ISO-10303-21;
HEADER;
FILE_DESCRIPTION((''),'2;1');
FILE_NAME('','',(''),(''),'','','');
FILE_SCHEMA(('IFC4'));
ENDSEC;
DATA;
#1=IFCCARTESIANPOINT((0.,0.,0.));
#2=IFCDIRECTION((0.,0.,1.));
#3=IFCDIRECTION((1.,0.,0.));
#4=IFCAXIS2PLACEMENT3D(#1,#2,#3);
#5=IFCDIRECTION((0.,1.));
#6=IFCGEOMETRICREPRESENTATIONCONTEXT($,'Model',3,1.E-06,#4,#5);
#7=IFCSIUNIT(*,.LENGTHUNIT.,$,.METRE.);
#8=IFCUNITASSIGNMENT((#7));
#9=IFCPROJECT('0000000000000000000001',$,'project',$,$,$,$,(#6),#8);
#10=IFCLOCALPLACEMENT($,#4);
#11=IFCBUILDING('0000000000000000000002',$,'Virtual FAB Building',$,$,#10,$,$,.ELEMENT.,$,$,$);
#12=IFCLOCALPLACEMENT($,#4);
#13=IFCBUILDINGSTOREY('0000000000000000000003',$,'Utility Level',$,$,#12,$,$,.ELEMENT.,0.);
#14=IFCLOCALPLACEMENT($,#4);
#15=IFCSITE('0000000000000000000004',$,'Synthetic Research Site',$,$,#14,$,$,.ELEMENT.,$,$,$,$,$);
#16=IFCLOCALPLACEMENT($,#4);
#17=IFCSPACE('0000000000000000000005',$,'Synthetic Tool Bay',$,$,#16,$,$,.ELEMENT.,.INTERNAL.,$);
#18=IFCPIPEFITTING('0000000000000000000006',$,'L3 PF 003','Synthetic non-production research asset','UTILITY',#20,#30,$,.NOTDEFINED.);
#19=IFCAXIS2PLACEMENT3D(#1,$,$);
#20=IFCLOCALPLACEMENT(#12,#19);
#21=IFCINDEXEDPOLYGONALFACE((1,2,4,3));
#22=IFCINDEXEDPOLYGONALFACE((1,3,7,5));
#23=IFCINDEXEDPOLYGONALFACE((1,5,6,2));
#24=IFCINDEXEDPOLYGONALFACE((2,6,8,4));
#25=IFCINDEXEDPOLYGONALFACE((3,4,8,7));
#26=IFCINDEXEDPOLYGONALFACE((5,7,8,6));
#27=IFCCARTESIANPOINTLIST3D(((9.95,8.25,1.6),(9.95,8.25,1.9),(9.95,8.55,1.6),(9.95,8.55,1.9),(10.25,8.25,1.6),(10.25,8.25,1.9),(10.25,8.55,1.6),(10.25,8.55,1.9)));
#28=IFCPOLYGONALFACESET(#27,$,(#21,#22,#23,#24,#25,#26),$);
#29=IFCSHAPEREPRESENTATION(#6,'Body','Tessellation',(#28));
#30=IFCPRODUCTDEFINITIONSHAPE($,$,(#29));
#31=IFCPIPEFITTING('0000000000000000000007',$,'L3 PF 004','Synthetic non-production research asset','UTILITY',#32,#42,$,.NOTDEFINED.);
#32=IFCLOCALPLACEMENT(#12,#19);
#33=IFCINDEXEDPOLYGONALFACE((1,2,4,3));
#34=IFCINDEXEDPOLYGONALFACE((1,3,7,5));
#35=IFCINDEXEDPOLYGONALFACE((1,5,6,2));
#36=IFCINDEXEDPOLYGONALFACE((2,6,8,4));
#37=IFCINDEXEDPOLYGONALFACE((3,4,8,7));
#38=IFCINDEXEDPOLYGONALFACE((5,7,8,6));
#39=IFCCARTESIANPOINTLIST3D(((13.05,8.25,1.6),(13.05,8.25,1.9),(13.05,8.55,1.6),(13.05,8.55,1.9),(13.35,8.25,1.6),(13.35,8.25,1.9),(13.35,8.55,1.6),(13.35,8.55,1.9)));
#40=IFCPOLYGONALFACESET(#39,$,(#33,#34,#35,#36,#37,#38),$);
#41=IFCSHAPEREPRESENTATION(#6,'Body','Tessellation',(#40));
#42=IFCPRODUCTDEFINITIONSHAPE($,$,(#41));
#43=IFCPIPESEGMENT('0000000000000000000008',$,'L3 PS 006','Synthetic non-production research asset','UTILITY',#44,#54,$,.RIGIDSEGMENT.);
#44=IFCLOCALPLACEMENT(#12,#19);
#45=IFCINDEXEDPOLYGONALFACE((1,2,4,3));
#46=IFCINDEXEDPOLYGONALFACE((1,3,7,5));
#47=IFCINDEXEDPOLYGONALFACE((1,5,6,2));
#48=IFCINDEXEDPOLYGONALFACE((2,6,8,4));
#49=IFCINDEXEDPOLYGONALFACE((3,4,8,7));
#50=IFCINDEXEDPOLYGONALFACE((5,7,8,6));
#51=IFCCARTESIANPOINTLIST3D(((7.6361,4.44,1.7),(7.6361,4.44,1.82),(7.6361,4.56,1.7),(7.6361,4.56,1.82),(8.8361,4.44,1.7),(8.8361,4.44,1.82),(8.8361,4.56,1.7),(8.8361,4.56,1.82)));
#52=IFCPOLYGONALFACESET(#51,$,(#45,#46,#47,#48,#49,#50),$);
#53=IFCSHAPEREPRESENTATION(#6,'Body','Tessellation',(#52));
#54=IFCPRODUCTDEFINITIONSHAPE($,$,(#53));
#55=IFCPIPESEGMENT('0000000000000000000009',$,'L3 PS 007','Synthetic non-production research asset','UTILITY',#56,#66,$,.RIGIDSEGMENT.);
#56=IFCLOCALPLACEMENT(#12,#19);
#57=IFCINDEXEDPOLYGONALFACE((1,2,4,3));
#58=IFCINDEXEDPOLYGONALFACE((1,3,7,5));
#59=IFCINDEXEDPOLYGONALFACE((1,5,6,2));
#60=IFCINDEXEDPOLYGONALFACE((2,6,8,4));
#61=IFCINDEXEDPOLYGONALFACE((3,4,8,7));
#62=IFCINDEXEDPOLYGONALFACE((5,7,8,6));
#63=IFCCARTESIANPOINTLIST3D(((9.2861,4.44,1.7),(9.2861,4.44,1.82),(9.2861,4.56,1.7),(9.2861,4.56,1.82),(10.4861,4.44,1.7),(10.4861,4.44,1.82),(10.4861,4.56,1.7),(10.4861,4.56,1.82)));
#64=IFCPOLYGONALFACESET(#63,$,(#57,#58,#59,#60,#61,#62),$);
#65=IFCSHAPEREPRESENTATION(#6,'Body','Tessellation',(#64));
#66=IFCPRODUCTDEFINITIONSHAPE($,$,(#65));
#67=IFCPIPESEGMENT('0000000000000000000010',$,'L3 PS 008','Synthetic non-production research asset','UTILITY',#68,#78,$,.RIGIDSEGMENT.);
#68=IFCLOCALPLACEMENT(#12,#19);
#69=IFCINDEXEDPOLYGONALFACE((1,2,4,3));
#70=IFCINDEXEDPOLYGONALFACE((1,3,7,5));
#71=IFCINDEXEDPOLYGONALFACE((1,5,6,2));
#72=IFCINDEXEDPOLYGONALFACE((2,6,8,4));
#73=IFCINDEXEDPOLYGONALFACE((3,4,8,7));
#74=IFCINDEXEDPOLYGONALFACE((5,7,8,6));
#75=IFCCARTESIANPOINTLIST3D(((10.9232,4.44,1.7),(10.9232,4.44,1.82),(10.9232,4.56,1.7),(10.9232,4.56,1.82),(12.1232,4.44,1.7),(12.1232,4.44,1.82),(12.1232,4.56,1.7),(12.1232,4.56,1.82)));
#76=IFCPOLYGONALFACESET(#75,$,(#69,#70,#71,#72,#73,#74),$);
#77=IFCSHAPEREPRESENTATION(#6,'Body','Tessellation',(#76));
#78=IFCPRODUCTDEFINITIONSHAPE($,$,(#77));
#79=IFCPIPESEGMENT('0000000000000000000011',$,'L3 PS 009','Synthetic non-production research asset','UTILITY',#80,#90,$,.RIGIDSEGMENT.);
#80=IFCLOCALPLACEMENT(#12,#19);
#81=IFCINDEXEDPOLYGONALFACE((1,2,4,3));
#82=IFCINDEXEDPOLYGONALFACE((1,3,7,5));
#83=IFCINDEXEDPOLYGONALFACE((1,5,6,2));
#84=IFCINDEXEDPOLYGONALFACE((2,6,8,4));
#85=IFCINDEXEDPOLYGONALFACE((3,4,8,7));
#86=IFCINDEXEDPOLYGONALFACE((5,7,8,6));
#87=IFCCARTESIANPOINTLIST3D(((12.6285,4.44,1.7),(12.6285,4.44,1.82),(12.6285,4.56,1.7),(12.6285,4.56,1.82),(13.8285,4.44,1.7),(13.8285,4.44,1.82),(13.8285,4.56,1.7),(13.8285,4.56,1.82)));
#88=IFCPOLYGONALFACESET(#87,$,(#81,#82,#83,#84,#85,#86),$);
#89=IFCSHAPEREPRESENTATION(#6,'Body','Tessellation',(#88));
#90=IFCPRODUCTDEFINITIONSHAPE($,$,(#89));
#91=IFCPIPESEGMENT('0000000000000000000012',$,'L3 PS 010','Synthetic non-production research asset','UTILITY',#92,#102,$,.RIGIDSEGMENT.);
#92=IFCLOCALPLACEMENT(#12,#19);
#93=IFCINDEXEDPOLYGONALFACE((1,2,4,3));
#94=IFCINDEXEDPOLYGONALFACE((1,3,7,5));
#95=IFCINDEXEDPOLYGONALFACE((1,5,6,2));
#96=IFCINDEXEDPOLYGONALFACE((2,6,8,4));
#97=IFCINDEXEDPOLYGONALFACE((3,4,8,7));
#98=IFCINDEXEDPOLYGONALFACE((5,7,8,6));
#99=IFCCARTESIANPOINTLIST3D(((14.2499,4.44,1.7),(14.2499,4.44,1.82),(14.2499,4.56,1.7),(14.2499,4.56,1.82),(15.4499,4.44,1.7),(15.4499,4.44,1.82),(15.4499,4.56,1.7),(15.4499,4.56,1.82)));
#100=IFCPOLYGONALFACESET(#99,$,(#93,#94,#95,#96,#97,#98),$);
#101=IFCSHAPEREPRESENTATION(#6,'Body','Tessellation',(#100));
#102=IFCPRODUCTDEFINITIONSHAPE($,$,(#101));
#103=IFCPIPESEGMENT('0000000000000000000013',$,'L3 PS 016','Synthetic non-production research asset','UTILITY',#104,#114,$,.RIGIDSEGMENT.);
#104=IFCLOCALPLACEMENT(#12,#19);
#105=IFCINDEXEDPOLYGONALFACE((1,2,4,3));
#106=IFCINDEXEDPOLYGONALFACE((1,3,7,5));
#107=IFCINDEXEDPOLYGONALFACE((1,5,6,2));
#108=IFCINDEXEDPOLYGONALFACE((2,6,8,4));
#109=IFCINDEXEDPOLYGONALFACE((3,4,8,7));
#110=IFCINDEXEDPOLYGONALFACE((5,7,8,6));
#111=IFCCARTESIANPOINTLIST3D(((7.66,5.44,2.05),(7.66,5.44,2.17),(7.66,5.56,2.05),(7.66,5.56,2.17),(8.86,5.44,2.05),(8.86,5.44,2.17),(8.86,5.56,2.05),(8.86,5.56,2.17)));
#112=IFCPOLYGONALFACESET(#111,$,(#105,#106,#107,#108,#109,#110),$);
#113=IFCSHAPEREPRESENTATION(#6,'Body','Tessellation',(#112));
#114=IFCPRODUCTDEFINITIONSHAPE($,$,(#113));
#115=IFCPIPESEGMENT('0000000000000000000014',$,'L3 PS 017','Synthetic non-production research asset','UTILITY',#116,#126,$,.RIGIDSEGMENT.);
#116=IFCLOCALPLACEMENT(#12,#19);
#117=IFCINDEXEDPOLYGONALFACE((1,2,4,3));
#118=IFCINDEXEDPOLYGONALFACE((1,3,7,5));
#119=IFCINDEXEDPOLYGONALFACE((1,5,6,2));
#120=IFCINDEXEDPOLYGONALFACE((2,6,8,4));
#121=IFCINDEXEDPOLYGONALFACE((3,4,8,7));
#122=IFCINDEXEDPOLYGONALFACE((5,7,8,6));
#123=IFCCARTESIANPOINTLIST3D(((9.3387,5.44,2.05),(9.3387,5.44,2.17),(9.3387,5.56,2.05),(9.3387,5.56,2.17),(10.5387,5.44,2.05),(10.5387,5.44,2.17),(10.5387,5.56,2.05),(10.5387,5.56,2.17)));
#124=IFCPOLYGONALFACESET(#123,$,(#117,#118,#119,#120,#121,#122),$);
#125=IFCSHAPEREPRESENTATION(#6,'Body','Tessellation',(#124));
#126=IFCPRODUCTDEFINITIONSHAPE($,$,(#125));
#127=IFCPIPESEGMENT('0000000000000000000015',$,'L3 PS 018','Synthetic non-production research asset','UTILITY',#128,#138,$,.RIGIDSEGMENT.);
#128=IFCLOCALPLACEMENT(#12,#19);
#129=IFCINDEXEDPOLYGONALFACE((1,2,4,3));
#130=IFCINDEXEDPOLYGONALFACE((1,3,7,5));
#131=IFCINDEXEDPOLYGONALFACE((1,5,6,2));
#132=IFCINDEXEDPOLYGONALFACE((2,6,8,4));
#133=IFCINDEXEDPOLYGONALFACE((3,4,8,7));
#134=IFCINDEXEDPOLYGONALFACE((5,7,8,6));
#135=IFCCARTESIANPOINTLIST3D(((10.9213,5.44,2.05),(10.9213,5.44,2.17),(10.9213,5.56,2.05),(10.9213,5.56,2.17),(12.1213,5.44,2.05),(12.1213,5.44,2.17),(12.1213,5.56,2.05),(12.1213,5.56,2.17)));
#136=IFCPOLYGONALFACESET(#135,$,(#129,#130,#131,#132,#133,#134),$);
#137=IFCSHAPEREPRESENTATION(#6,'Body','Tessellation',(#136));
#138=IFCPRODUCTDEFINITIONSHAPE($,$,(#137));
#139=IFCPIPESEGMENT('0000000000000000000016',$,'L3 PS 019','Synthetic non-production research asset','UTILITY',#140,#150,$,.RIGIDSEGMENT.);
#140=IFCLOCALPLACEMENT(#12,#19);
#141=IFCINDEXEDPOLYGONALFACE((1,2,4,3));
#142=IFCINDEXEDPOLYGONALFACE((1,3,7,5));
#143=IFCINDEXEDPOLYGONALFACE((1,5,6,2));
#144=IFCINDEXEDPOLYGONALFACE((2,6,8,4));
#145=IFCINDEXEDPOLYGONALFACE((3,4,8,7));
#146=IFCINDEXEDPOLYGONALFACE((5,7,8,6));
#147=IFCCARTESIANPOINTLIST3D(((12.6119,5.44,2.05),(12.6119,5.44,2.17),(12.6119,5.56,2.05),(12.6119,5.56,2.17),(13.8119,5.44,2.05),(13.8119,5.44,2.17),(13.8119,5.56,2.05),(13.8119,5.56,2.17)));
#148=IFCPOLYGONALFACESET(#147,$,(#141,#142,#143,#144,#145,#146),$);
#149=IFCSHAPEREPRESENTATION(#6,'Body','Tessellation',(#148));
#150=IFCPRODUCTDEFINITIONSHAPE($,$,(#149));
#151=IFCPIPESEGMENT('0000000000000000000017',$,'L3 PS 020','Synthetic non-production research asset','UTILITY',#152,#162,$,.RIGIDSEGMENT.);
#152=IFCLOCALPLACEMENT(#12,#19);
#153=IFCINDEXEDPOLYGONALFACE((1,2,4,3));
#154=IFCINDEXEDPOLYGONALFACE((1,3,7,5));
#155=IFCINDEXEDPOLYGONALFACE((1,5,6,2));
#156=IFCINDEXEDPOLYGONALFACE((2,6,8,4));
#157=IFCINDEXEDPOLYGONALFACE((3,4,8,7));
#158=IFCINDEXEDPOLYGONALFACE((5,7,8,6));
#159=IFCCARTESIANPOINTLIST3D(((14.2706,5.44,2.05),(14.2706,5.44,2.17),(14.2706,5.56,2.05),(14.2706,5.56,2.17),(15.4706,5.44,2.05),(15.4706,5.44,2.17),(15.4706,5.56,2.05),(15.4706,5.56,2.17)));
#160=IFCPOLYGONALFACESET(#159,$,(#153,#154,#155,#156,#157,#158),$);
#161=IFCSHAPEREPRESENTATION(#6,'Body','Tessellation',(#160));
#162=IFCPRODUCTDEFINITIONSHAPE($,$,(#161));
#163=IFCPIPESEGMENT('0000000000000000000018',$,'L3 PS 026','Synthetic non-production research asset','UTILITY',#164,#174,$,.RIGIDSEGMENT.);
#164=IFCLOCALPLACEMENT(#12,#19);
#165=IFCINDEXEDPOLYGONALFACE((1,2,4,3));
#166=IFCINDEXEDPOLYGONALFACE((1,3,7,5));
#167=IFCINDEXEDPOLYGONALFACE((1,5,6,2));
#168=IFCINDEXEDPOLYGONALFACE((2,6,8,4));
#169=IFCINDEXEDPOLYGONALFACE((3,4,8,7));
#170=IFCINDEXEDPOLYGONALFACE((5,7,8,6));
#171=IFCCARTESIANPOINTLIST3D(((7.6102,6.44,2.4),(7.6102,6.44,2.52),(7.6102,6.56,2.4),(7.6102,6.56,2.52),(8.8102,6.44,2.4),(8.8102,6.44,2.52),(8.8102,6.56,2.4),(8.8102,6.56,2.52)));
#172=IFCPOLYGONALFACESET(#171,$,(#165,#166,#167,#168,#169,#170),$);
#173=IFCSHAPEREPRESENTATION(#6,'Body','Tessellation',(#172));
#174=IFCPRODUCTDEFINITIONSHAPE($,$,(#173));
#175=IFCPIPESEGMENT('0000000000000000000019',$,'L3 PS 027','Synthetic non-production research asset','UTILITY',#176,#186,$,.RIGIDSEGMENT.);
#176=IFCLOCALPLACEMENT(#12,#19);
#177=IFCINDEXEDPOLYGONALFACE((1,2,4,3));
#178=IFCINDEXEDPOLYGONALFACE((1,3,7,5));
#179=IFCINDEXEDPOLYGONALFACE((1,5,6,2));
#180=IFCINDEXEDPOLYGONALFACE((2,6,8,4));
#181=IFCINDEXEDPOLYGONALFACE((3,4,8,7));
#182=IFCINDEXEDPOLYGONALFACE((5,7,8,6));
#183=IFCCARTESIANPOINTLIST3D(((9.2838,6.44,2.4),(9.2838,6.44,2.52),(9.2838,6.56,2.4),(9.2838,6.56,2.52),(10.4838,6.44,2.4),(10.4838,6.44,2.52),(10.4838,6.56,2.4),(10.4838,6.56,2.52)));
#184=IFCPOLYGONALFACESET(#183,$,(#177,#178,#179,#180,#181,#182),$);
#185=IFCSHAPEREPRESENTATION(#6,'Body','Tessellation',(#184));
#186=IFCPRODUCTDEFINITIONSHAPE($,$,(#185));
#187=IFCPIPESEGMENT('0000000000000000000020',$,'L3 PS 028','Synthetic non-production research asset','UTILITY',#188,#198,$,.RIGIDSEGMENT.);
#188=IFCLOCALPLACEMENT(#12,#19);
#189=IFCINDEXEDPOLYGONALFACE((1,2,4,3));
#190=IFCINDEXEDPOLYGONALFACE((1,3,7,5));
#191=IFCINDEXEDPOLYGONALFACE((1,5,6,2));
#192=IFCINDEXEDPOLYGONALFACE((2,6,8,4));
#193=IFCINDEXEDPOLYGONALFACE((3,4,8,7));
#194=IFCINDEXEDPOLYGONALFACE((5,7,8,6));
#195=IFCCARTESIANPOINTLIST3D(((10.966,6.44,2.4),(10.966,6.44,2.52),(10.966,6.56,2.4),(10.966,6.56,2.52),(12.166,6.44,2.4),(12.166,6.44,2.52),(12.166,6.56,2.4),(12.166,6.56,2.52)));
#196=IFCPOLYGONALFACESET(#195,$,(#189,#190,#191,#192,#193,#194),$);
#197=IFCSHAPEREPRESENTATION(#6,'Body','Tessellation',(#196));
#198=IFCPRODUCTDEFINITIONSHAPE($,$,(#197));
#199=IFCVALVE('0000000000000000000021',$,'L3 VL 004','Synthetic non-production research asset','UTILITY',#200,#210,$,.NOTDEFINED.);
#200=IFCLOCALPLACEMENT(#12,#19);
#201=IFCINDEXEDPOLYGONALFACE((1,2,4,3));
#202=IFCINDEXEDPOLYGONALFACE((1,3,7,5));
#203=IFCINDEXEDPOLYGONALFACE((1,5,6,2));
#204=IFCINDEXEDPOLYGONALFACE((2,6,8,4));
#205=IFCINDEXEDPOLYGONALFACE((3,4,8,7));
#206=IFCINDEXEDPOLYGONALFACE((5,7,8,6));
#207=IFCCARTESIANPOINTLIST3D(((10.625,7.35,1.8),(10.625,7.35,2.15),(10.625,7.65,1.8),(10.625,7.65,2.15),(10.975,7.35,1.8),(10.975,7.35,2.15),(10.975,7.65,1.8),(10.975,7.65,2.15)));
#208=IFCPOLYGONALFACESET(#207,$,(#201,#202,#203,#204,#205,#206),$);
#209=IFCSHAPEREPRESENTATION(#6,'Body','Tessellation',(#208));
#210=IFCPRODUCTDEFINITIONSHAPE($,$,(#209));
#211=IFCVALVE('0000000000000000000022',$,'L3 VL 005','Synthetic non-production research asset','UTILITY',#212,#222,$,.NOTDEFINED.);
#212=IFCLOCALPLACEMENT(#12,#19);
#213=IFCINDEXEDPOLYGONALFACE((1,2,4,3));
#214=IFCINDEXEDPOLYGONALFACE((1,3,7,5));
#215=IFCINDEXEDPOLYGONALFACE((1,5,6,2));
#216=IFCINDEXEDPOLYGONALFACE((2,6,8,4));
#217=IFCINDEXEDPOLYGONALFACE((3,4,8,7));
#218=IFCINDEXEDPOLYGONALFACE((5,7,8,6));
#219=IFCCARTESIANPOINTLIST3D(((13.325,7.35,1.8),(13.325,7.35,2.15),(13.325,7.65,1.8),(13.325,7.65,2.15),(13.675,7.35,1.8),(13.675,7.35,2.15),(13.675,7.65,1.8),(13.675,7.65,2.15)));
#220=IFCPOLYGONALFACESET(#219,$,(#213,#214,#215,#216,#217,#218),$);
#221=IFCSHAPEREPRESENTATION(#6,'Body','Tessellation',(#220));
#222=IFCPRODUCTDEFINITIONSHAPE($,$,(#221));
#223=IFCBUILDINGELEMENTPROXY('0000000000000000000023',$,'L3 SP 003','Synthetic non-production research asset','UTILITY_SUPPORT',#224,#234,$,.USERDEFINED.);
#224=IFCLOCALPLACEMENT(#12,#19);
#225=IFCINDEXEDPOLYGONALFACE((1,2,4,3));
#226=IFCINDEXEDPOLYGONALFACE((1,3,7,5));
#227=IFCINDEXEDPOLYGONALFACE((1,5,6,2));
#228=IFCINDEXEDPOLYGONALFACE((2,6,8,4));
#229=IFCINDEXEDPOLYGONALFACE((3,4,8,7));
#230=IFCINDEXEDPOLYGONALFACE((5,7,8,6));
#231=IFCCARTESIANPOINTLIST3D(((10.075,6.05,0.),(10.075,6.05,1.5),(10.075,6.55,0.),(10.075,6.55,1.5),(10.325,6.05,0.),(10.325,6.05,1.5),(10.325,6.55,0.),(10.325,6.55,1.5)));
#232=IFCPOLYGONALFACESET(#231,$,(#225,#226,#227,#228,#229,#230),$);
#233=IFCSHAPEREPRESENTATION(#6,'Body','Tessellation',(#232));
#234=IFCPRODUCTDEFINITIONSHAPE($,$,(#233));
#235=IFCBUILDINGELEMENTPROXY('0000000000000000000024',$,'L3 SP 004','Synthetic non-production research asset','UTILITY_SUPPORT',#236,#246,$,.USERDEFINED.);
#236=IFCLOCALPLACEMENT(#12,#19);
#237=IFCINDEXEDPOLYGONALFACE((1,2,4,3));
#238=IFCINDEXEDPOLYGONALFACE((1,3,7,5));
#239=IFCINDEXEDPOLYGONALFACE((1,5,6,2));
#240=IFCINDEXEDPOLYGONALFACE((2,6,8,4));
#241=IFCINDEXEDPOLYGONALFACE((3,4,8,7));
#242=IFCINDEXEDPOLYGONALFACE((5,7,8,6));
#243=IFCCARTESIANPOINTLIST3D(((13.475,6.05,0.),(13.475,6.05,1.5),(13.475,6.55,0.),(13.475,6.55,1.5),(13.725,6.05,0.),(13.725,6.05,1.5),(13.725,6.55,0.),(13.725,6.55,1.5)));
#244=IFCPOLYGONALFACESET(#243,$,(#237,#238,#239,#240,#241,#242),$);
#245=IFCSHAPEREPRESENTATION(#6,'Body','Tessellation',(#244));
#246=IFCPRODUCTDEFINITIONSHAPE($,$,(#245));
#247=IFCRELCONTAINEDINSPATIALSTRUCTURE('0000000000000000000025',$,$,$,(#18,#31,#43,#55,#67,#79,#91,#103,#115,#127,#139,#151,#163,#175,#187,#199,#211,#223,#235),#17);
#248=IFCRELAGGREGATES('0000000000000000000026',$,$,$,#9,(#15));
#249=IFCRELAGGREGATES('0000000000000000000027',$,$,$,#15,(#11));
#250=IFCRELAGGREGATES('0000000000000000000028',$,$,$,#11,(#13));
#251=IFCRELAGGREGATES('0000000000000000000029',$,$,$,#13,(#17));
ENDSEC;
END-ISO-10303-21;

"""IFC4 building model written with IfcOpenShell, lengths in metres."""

from ifc_helpers import new_model, si_unit, direction, frame, origin_with_axes, origin_2d_with_axis, place, context, project, spatial, rectangle, extrude, element, save


model = new_model("IFC4")

# Units and contexts
model_context = context("Model", 3, precision=1e-06, world=origin_with_axes(), true_north=direction((0.0, 1.0)))
ifc_project = project(units=[si_unit("LENGTHUNIT", "METRE")], contexts=[model_context])

# Site, building, storey, space
site_placement = place(None, origin_with_axes())
site = spatial("IfcSite", under=ifc_project, at=site_placement, Name="Synthetic Research Site", CompositionType="ELEMENT")
building_placement = place(None, origin_with_axes())
building = spatial("IfcBuilding", under=site, at=building_placement, Name="Virtual FAB Building", CompositionType="ELEMENT")
storey_placement = place(None, origin_with_axes())
storey = spatial("IfcBuildingStorey", under=building, at=storey_placement, Name="Utility Level", CompositionType="ELEMENT", Elevation=0.0)
space_placement = place(None, origin_with_axes())
space = spatial("IfcSpace", under=storey, at=space_placement, Name="Synthetic Tool Bay", CompositionType="ELEMENT", PredefinedType="INTERNAL")

# Pipe fittings
for number, where, z_axis, x_axis, name in (
    (1, (10.1, 8.4, 1.6), (0.0, 0.0, 1.0), (1.0, 0.0, 0.0), "L3 PF 003"),
    (2, (13.2, 8.4, 1.6), (0.0, 0.0, 1.0), (1.0, 0.0, 0.0), "L3 PF 004"),
):
    element("IfcPipeFitting", number, at=place(None, frame(where, z_axis=z_axis, x_axis=x_axis)), inside=space, Name=name, Description="Synthetic non-production research asset", ObjectType="UTILITY", PredefinedType="NOTDEFINED", context=model_context, shape_type="SweptSolid", body=[
        extrude(rectangle(XDim=0.3, YDim=0.3, at=origin_2d_with_axis()), origin_with_axes(), (0.0, 0.0, 1.0), 0.3),
    ])

# Pipe segments
for number, where, z_axis, x_axis, name in (
    (3, (8.2361, 4.5, 1.7), (0.0, 0.0, 1.0), (1.0, 0.0, 0.0), "L3 PS 006"),
    (4, (9.8861, 4.5, 1.7), (0.0, 0.0, 1.0), (1.0, 0.0, 0.0), "L3 PS 007"),
    (5, (11.5232, 4.5, 1.7), (0.0, 0.0, 1.0), (1.0, 0.0, 0.0), "L3 PS 008"),
    (6, (13.2285, 4.5, 1.7), (0.0, 0.0, 1.0), (1.0, 0.0, 0.0), "L3 PS 009"),
    (7, (14.8499, 4.5, 1.7), (0.0, 0.0, 1.0), (1.0, 0.0, 0.0), "L3 PS 010"),
    (8, (8.26, 5.5, 2.05), (0.0, 0.0, 1.0), (1.0, 0.0, 0.0), "L3 PS 016"),
    (9, (9.9387, 5.5, 2.05), (0.0, 0.0, 1.0), (1.0, 0.0, 0.0), "L3 PS 017"),
    (10, (11.5213, 5.5, 2.05), (0.0, 0.0, 1.0), (1.0, 0.0, 0.0), "L3 PS 018"),
    (11, (13.2119, 5.5, 2.05), (0.0, 0.0, 1.0), (1.0, 0.0, 0.0), "L3 PS 019"),
    (12, (14.8706, 5.5, 2.05), (0.0, 0.0, 1.0), (1.0, 0.0, 0.0), "L3 PS 020"),
    (13, (8.2102, 6.5, 2.4), (0.0, 0.0, 1.0), (1.0, 0.0, 0.0), "L3 PS 026"),
    (14, (9.8838, 6.5, 2.4), (0.0, 0.0, 1.0), (1.0, 0.0, 0.0), "L3 PS 027"),
    (15, (11.566, 6.5, 2.4), (0.0, 0.0, 1.0), (1.0, 0.0, 0.0), "L3 PS 028"),
):
    element("IfcPipeSegment", number, at=place(None, frame(where, z_axis=z_axis, x_axis=x_axis)), inside=space, Name=name, Description="Synthetic non-production research asset", ObjectType="UTILITY", PredefinedType="RIGIDSEGMENT", context=model_context, shape_type="SweptSolid", body=[
        extrude(rectangle(XDim=1.2, YDim=0.12, at=origin_2d_with_axis()), origin_with_axes(), (0.0, 0.0, 1.0), 0.12),
    ])

# Valves
for number, where, z_axis, x_axis, name in (
    (16, (10.8, 7.5, 1.8), (0.0, 0.0, 1.0), (1.0, 0.0, 0.0), "L3 VL 004"),
    (17, (13.5, 7.5, 1.8), (0.0, 0.0, 1.0), (1.0, 0.0, 0.0), "L3 VL 005"),
):
    element("IfcValve", number, at=place(None, frame(where, z_axis=z_axis, x_axis=x_axis)), inside=space, Name=name, Description="Synthetic non-production research asset", ObjectType="UTILITY", PredefinedType="NOTDEFINED", context=model_context, shape_type="SweptSolid", body=[
        extrude(rectangle(XDim=0.35, YDim=0.3, at=origin_2d_with_axis()), origin_with_axes(), (0.0, 0.0, 1.0), 0.35),
    ])

# Building element proxies
for number, where, z_axis, x_axis, name in (
    (18, (10.2, 6.3, 0.0), (0.0, 0.0, 1.0), (1.0, 0.0, 0.0), "L3 SP 003"),
    (19, (13.6, 6.3, 0.0), (0.0, 0.0, 1.0), (1.0, 0.0, 0.0), "L3 SP 004"),
):
    element("IfcBuildingElementProxy", number, at=place(None, frame(where, z_axis=z_axis, x_axis=x_axis)), inside=space, Name=name, Description="Synthetic non-production research asset", ObjectType="UTILITY_SUPPORT", PredefinedType="USERDEFINED", context=model_context, shape_type="SweptSolid", body=[
        extrude(rectangle(XDim=0.25, YDim=0.5, at=origin_2d_with_axis()), origin_with_axes(), (0.0, 0.0, 1.0), 1.5),
    ])

save(model, "model.ifc")
